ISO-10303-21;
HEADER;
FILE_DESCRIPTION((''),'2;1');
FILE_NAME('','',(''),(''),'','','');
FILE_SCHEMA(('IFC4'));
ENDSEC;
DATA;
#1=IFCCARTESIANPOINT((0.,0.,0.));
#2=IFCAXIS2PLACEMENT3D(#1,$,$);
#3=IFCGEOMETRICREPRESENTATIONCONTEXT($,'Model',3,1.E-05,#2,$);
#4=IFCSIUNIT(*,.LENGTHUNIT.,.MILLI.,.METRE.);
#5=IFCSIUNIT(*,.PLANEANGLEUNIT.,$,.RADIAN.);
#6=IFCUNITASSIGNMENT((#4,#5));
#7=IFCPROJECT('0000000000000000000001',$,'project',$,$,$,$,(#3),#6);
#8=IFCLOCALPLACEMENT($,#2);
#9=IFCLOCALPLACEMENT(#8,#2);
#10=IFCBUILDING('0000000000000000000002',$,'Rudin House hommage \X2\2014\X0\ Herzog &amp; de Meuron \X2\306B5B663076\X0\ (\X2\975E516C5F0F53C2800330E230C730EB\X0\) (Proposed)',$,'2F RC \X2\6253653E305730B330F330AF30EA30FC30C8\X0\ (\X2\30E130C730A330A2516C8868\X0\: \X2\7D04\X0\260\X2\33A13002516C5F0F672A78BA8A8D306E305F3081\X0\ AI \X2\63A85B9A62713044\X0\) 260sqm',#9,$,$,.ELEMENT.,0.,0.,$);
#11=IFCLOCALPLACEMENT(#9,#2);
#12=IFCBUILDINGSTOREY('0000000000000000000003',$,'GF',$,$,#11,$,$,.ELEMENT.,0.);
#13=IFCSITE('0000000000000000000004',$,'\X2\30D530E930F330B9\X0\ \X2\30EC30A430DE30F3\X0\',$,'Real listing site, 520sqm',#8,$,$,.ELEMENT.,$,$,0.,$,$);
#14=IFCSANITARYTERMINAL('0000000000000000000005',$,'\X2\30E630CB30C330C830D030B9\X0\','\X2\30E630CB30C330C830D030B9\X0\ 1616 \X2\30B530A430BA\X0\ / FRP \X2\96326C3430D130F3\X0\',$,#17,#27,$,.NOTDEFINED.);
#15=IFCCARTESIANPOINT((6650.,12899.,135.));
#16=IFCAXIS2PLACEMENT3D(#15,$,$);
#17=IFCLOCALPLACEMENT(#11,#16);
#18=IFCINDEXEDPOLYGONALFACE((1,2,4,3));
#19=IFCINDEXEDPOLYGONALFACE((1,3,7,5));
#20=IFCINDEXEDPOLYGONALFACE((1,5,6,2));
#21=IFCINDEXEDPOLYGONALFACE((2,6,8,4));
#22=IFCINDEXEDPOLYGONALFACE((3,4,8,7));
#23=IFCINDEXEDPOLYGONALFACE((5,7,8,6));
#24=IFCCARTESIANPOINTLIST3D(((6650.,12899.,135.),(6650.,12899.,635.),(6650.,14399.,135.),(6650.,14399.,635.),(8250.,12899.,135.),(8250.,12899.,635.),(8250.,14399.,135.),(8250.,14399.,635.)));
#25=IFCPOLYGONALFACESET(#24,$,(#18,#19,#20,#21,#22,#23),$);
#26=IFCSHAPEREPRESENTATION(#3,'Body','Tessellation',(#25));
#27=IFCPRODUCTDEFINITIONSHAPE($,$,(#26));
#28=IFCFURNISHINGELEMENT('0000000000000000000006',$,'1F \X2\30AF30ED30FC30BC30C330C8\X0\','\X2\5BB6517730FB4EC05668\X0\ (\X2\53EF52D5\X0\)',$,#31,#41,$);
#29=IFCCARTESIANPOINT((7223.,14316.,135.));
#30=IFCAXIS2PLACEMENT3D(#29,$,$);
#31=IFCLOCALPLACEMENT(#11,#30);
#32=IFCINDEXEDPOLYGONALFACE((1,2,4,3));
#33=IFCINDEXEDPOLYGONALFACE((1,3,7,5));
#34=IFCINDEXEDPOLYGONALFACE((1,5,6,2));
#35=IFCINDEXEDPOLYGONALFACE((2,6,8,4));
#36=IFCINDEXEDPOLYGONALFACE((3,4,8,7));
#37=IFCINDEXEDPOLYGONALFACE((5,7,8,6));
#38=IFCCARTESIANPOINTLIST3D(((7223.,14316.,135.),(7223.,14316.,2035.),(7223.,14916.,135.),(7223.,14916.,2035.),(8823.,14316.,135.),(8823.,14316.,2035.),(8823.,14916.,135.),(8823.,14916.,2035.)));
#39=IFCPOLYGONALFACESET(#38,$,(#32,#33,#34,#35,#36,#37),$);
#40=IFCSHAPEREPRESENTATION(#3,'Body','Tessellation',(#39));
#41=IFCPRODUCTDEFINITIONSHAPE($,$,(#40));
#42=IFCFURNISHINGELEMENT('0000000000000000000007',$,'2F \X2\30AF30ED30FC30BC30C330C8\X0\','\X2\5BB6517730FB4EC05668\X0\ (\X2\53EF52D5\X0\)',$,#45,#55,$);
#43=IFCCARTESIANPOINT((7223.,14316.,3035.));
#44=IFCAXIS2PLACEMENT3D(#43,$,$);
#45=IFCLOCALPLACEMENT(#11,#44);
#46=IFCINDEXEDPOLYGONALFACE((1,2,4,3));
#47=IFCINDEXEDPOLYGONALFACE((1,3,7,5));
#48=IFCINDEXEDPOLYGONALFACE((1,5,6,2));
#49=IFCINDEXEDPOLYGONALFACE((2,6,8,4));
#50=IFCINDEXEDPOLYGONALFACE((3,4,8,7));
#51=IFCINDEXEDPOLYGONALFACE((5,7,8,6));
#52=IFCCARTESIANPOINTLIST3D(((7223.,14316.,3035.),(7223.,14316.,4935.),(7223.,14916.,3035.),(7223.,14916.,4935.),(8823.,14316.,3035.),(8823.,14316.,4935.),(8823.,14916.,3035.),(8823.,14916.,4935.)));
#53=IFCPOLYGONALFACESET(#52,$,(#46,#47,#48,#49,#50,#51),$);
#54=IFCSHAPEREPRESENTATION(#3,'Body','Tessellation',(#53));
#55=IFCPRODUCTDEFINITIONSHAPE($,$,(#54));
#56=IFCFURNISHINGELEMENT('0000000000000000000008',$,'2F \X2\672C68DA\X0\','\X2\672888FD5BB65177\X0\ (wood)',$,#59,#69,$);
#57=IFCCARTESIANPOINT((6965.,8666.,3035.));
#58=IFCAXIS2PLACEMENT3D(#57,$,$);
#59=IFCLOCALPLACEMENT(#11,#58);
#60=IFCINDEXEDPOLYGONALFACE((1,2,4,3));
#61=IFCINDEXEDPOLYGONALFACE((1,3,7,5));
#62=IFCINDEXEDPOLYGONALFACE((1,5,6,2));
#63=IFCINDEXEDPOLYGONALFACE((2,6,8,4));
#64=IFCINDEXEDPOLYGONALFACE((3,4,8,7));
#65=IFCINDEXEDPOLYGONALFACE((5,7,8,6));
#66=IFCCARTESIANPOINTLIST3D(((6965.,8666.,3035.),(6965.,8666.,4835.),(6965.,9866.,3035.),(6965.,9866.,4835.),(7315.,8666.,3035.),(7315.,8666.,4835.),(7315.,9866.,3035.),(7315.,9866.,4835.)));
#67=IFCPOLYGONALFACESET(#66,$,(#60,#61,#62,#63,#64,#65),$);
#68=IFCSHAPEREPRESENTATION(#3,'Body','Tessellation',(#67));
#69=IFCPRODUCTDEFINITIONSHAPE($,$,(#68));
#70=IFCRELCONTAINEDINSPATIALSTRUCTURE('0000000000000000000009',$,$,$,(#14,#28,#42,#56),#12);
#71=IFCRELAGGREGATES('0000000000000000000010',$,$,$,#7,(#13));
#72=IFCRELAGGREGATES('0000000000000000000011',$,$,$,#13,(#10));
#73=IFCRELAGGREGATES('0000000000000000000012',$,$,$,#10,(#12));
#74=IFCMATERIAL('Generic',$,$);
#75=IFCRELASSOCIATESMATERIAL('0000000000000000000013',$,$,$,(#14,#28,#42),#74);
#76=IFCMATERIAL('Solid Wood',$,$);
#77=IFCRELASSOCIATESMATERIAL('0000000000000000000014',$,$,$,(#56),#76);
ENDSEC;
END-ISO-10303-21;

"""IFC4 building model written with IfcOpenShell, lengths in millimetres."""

from ifc_helpers import new_model, si_unit, frame, frame_2d, origin, place, context, project, spatial, rectangle, extrude, material, element, save


model = new_model("IFC4")

# Units and contexts
model_context = context("Model", 3, precision=1e-05, world=origin())
ifc_project = project(units=[si_unit("LENGTHUNIT", "METRE", prefix="MILLI"), si_unit("PLANEANGLEUNIT", "RADIAN")], contexts=[model_context])

# Site, building, storey
site_placement = place(None, origin())
site = spatial("IfcSite", under=ifc_project, at=site_placement, Name="フランス レイマン", ObjectType="Real listing site, 520sqm", CompositionType="ELEMENT", RefElevation=0.0)
building_placement = place(site_placement, origin())
building = spatial("IfcBuilding", under=site, at=building_placement, Name="Rudin House hommage — Herzog &amp; de Meuron に学ぶ (非公式参考モデル) (Proposed)", ObjectType="2F RC 打放しコンクリート (メディア公表: 約260㎡。公式未確認のため AI 推定扱い) 260sqm", CompositionType="ELEMENT", ElevationOfRefHeight=0.0, ElevationOfTerrain=0.0)
storey_placement = place(building_placement, origin())
storey = spatial("IfcBuildingStorey", under=building, at=storey_placement, Name="GF", CompositionType="ELEMENT", Elevation=0.0)

# Shared definitions
ifc_material_1 = material(Name="Solid Wood")

# Shared definitions
ifc_material_2 = material(Name="Generic")

# Sanitary terminal
sanitary_terminal_placement = place(storey_placement, frame((6650.0, 12899.0, 135.0)))
element("IfcSanitaryTerminal", 1, at=sanitary_terminal_placement, inside=storey, material=ifc_material_2, Name="ユニットバス", Description="ユニットバス 1616 サイズ / FRP 防水パン", PredefinedType="NOTDEFINED", context=model_context, shape_type="SweptSolid", body=[
    extrude(rectangle(XDim=1600.0, YDim=1500.0, at=frame_2d((800.0, 750.0))), frame((6650.0, 12899.0, 135.0)), (0.0, 0.0, 1.0), 500.0),
])

# Furnishing elements
furnishing_1_placement = place(storey_placement, frame((7223.0, 14316.0, 135.0)))
element("IfcFurnishingElement", 2, at=furnishing_1_placement, inside=storey, material=ifc_material_2, Name="1F クローゼット", Description="家具・什器 (可動)", context=model_context, shape_type="SweptSolid", body=[
    extrude(rectangle(XDim=1600.0, YDim=600.0, at=frame_2d((800.0, 300.0))), frame((7223.0, 14316.0, 135.0)), (0.0, 0.0, 1.0), 1900.0),
])
furnishing_2_placement = place(storey_placement, frame((7223.0, 14316.0, 3035.0)))
element("IfcFurnishingElement", 3, at=furnishing_2_placement, inside=storey, material=ifc_material_2, Name="2F クローゼット", Description="家具・什器 (可動)", context=model_context, shape_type="SweptSolid", body=[
    extrude(rectangle(XDim=1600.0, YDim=600.0, at=frame_2d((800.0, 300.0))), frame((7223.0, 14316.0, 3035.0)), (0.0, 0.0, 1.0), 1900.0),
])
furnishing_3_placement = place(storey_placement, frame((6965.0, 8666.0, 3035.0)))
element("IfcFurnishingElement", 4, at=furnishing_3_placement, inside=storey, material=ifc_material_1, Name="2F 本棚", Description="木製家具 (wood)", context=model_context, shape_type="SweptSolid", body=[
    extrude(rectangle(XDim=350.0, YDim=1200.0, at=frame_2d((175.0, 600.0))), frame((6965.0, 8666.0, 3035.0)), (0.0, 0.0, 1.0), 1800.0),
])

save(model, "model.ifc")
